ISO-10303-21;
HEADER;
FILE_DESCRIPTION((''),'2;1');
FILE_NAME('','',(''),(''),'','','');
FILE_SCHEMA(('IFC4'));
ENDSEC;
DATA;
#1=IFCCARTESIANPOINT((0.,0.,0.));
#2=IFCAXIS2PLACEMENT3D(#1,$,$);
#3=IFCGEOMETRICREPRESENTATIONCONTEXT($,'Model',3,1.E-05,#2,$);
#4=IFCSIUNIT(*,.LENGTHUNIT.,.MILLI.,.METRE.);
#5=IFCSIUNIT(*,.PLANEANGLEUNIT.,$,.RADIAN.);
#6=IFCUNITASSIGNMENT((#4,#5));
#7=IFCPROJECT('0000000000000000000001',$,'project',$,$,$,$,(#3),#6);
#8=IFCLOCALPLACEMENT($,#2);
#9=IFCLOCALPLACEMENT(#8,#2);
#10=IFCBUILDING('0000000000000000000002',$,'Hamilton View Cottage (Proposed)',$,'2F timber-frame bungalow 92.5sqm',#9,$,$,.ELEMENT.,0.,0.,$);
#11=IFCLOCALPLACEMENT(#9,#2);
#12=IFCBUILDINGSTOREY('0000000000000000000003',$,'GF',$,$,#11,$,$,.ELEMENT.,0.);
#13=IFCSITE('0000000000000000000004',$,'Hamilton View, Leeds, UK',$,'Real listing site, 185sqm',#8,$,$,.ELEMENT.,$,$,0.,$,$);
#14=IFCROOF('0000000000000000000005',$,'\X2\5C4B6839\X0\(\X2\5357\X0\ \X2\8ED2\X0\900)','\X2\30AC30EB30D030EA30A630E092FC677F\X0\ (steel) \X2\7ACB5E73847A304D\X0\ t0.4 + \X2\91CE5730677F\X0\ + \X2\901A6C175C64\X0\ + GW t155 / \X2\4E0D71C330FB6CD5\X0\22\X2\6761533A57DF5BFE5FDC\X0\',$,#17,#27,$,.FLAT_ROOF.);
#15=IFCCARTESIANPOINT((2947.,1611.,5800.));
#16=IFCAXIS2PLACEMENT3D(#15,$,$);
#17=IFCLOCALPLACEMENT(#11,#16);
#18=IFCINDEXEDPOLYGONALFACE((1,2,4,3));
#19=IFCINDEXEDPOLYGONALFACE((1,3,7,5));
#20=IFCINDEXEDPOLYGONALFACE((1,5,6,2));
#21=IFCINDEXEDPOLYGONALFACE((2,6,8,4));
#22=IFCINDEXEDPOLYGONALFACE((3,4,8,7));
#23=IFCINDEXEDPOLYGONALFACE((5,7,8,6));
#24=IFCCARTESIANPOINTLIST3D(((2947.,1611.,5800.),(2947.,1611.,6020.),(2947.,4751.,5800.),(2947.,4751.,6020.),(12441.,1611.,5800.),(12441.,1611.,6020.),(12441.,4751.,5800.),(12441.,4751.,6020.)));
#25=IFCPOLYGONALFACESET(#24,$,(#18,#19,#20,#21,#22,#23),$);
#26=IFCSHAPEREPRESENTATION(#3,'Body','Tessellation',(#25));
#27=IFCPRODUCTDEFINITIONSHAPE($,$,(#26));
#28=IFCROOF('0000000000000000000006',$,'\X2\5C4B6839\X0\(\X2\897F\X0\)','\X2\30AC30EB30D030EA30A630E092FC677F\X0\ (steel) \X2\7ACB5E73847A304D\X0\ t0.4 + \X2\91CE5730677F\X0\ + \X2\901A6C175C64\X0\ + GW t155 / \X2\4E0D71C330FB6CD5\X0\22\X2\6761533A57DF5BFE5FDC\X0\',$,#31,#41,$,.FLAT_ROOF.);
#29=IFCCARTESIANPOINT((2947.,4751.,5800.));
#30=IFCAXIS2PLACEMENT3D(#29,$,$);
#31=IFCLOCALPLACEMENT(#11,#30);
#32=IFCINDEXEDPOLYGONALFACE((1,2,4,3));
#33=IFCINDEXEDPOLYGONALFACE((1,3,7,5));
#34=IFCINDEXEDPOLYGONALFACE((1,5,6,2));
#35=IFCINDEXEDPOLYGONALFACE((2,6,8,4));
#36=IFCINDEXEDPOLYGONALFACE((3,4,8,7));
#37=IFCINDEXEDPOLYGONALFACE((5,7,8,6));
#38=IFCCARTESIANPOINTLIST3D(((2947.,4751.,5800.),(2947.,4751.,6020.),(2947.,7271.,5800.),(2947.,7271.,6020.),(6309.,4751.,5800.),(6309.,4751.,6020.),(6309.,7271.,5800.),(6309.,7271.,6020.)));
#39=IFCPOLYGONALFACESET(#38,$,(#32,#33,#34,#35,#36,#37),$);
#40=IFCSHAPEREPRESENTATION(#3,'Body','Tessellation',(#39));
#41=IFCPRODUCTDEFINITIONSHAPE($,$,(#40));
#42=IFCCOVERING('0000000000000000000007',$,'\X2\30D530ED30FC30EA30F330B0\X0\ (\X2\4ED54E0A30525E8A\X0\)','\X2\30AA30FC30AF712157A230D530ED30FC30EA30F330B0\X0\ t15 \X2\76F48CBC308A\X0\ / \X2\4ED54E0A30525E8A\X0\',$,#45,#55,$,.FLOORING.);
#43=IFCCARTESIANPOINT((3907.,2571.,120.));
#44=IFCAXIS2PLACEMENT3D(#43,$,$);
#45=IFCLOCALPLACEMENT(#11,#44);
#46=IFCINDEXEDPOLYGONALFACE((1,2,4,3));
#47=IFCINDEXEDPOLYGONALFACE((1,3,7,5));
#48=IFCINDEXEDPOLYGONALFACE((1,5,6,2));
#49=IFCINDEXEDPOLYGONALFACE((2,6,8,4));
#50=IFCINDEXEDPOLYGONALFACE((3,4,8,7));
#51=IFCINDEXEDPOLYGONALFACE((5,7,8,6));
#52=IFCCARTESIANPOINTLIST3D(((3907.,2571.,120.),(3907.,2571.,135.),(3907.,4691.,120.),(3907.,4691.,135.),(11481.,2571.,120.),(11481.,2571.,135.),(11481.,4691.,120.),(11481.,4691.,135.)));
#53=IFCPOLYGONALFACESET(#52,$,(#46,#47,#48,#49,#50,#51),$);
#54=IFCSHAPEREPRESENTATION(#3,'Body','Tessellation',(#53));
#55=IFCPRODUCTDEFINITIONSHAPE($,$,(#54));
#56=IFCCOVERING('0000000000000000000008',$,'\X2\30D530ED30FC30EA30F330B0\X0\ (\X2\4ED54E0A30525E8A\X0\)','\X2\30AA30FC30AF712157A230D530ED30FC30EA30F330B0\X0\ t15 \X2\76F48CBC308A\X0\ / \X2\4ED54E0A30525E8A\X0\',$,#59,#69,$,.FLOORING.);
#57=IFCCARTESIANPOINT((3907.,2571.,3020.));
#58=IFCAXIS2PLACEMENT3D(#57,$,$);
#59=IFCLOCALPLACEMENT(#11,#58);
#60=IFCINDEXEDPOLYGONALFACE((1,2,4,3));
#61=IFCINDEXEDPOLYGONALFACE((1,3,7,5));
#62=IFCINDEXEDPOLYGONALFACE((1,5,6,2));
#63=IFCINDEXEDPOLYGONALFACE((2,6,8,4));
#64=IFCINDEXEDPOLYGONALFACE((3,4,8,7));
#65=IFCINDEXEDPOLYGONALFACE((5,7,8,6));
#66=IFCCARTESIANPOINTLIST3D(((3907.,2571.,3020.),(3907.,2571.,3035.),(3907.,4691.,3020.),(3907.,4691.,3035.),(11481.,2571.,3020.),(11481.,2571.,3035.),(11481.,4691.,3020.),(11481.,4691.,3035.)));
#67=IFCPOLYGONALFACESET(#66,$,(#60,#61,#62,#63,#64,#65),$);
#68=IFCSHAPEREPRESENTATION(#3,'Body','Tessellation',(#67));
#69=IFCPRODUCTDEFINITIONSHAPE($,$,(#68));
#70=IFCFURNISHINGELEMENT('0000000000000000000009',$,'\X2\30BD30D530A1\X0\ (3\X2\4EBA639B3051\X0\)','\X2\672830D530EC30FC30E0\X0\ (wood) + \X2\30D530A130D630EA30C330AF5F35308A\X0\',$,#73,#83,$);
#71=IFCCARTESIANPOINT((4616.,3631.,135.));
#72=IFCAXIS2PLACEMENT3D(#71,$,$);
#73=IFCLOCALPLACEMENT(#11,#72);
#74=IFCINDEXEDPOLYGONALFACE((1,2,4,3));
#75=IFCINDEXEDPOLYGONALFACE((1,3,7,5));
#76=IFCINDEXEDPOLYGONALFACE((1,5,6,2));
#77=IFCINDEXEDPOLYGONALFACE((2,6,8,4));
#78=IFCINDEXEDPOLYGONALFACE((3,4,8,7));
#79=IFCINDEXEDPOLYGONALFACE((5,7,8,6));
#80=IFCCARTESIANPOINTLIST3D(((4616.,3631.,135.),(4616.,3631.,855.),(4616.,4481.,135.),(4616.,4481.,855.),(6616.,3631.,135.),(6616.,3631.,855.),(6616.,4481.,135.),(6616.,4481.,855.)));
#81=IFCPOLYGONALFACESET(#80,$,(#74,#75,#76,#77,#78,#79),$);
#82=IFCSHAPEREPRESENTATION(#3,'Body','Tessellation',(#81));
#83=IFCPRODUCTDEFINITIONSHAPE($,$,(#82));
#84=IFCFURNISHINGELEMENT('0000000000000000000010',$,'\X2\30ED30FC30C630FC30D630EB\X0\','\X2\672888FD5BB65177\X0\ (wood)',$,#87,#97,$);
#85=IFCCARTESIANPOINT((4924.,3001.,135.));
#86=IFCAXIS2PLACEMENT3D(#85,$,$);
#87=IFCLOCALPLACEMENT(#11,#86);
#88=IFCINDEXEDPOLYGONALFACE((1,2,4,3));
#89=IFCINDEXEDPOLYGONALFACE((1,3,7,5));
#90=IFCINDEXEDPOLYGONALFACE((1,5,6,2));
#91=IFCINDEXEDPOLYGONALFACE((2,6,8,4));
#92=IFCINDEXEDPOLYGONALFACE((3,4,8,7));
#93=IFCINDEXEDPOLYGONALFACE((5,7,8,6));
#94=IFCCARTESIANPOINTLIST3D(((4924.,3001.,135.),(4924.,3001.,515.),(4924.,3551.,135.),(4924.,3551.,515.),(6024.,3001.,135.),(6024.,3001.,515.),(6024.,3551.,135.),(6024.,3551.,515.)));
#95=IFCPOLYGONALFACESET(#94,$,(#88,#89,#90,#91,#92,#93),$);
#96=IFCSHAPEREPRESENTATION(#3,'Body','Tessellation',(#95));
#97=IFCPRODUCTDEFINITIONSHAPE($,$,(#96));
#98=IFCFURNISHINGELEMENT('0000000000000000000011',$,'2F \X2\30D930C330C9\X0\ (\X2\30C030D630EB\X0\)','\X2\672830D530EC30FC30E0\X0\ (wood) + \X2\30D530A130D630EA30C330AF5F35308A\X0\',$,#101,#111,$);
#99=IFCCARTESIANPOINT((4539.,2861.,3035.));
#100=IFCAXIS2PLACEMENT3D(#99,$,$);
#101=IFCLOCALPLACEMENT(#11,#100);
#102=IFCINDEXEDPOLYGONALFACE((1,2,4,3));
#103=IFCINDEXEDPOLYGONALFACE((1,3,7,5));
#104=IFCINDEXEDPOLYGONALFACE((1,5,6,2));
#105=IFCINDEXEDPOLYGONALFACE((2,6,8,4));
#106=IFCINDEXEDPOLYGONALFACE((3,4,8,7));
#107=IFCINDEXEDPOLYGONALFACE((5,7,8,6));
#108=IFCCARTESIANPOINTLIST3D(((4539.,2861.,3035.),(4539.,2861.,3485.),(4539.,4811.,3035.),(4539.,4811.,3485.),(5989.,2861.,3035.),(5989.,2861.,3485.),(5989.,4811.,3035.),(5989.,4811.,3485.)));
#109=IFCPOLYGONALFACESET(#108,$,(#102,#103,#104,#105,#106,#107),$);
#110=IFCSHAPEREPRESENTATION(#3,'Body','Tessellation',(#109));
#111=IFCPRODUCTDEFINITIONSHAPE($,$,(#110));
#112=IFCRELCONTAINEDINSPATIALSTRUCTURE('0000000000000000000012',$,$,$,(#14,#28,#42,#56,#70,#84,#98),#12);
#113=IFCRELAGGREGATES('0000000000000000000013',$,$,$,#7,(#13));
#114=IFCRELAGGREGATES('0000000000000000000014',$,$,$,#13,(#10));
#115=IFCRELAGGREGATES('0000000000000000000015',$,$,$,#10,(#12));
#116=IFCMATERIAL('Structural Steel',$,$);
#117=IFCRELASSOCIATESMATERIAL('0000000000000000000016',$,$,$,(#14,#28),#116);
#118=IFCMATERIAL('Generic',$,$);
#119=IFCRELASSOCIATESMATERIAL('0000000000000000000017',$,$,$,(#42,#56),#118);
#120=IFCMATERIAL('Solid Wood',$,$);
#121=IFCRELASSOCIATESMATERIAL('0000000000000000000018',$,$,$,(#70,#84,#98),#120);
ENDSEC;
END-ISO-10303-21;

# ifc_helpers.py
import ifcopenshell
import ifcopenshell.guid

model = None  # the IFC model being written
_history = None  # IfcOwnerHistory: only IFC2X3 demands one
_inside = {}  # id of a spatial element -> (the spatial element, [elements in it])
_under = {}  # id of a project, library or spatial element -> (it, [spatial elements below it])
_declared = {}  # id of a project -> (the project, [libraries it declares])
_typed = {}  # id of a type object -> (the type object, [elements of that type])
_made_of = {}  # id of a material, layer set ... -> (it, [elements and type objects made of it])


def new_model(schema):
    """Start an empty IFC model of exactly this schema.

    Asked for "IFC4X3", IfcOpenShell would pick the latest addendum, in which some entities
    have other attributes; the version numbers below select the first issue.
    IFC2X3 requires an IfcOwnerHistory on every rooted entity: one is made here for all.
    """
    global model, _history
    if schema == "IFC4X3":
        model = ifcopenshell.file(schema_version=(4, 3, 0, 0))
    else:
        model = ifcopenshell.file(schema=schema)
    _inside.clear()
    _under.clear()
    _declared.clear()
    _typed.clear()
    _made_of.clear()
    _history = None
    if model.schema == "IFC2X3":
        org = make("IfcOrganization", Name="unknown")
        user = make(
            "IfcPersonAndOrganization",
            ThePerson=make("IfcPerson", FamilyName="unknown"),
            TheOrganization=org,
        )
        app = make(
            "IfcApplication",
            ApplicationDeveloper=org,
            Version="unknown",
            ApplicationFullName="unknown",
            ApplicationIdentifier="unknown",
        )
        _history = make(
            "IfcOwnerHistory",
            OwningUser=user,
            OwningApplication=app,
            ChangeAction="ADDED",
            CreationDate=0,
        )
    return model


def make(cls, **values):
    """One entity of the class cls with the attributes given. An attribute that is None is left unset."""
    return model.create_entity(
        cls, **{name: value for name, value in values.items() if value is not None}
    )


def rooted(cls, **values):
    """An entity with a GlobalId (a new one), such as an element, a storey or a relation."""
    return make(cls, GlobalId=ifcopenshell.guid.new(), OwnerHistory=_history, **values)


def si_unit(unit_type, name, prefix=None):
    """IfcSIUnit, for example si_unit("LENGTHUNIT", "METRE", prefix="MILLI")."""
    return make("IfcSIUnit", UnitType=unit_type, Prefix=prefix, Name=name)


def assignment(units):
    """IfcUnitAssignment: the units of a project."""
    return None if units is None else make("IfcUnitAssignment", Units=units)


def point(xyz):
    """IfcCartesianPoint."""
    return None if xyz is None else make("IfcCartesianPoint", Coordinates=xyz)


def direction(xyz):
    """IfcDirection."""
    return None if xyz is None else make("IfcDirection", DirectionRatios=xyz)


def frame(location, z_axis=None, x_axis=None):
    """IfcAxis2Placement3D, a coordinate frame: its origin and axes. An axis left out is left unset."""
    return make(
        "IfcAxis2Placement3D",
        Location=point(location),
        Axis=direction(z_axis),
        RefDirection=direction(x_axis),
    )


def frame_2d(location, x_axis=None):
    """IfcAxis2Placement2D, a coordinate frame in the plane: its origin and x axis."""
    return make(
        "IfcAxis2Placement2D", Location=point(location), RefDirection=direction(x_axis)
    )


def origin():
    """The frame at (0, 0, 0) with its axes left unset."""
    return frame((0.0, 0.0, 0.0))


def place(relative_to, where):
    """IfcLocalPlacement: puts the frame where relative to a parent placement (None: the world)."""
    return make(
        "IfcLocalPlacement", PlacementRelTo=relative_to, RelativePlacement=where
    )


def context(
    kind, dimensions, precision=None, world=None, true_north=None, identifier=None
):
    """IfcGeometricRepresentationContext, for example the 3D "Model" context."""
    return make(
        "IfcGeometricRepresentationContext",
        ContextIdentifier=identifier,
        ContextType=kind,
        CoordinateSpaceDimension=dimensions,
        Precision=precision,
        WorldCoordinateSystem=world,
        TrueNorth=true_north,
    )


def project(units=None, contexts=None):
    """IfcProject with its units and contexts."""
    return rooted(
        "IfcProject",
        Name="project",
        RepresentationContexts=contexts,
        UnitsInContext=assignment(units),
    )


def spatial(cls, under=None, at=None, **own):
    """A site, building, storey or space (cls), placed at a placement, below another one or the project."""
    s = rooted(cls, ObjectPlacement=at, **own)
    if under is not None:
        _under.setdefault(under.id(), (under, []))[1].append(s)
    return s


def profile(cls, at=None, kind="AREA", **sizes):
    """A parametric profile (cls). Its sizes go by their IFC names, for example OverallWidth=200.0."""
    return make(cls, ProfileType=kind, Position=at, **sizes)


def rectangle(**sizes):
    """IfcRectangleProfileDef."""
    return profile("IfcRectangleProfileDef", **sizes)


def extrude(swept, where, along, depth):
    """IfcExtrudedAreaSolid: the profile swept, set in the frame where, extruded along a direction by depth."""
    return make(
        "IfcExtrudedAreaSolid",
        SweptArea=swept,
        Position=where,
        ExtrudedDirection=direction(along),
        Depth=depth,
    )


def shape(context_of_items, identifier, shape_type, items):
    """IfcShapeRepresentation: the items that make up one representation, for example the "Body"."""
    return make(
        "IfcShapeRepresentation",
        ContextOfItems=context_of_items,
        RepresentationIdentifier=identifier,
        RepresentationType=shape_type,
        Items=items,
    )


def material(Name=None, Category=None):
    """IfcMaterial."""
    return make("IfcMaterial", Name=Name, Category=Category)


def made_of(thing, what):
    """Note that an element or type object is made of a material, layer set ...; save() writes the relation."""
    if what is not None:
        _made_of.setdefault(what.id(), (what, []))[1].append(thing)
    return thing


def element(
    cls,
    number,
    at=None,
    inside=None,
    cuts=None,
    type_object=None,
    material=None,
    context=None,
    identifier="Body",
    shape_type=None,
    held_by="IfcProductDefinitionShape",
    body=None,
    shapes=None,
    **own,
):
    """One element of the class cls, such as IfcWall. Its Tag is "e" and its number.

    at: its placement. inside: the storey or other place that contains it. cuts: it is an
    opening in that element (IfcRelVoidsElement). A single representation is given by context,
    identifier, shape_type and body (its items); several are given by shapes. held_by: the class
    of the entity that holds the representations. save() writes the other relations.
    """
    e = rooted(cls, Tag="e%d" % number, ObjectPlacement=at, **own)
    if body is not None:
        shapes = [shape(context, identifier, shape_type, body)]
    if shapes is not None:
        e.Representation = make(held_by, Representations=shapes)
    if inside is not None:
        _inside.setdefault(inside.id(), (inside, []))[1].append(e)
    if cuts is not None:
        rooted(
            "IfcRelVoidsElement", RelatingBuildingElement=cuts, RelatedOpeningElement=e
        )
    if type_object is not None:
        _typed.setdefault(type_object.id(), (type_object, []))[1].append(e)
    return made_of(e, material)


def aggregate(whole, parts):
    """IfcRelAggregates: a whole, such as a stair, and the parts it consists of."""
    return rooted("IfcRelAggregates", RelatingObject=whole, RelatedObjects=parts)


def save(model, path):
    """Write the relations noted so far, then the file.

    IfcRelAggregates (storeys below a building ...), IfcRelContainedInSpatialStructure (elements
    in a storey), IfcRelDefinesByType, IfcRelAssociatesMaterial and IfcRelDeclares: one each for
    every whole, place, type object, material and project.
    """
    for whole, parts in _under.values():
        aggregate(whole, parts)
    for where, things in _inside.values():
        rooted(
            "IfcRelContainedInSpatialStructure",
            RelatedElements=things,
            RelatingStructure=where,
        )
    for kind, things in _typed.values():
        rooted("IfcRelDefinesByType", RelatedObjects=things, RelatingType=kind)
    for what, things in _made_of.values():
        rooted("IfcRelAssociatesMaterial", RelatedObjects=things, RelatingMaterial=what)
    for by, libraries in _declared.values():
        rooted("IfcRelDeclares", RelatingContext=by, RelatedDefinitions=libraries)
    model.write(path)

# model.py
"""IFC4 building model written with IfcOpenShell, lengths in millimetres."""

from ifc_helpers import new_model, si_unit, frame, frame_2d, origin, place, context, project, spatial, rectangle, extrude, material, element, save


model = new_model("IFC4")

# Units and contexts
model_context = context("Model", 3, precision=1e-05, world=origin())
ifc_project = project(units=[si_unit("LENGTHUNIT", "METRE", prefix="MILLI"), si_unit("PLANEANGLEUNIT", "RADIAN")], contexts=[model_context])

# Site, building, storey
site_placement = place(None, origin())
site = spatial("IfcSite", under=ifc_project, at=site_placement, Name="Hamilton View, Leeds, UK", ObjectType="Real listing site, 185sqm", CompositionType="ELEMENT", RefElevation=0.0)
building_placement = place(site_placement, origin())
building = spatial("IfcBuilding", under=site, at=building_placement, Name="Hamilton View Cottage (Proposed)", ObjectType="2F timber-frame bungalow 92.5sqm", CompositionType="ELEMENT", ElevationOfRefHeight=0.0, ElevationOfTerrain=0.0)
storey_placement = place(building_placement, origin())
storey = spatial("IfcBuildingStorey", under=building, at=storey_placement, Name="GF", CompositionType="ELEMENT", Elevation=0.0)

# Shared definitions
ifc_material_1 = material(Name="Solid Wood")

# Roofs
ifc_material_2 = material(Name="Structural Steel")
roof_1_placement = place(storey_placement, frame((2947.0, 1611.0, 5800.0)))
element("IfcRoof", 1, at=roof_1_placement, inside=storey, material=ifc_material_2, Name="屋根(南 軒900)", Description="ガルバリウム鋼板 (steel) 立平葺き t0.4 + 野地板 + 通気層 + GW t155 / 不燃・法22条区域対応", PredefinedType="FLAT_ROOF", context=model_context, shape_type="SweptSolid", body=[
    extrude(rectangle(XDim=9494.0, YDim=3140.0, at=frame_2d((4747.0, 1570.0))), frame((2947.0, 1611.0, 5800.0)), (0.0, 0.0, 1.0), 220.0),
])
roof_2_placement = place(storey_placement, frame((2947.0, 4751.0, 5800.0)))
element("IfcRoof", 2, at=roof_2_placement, inside=storey, material=ifc_material_2, Name="屋根(西)", Description="ガルバリウム鋼板 (steel) 立平葺き t0.4 + 野地板 + 通気層 + GW t155 / 不燃・法22条区域対応", PredefinedType="FLAT_ROOF", context=model_context, shape_type="SweptSolid", body=[
    extrude(rectangle(XDim=3362.0, YDim=2520.0, at=frame_2d((1681.0, 1260.0))), frame((2947.0, 4751.0, 5800.0)), (0.0, 0.0, 1.0), 220.0),
])

# Coverings
ifc_material_3 = material(Name="Generic")
covering_1_placement = place(storey_placement, frame((3907.0, 2571.0, 120.0)))
element("IfcCovering", 3, at=covering_1_placement, inside=storey, material=ifc_material_3, Name="フローリング (仕上げ床)", Description="オーク無垢フローリング t15 直貼り / 仕上げ床", PredefinedType="FLOORING", context=model_context, shape_type="SweptSolid", body=[
    extrude(rectangle(XDim=7574.0, YDim=2120.0, at=frame_2d((3787.0, 1060.0))), frame((3907.0, 2571.0, 120.0)), (0.0, 0.0, 1.0), 15.0),
])
covering_2_placement = place(storey_placement, frame((3907.0, 2571.0, 3020.0)))
element("IfcCovering", 4, at=covering_2_placement, inside=storey, material=ifc_material_3, Name="フローリング (仕上げ床)", Description="オーク無垢フローリング t15 直貼り / 仕上げ床", PredefinedType="FLOORING", context=model_context, shape_type="SweptSolid", body=[
    extrude(rectangle(XDim=7574.0, YDim=2120.0, at=frame_2d((3787.0, 1060.0))), frame((3907.0, 2571.0, 3020.0)), (0.0, 0.0, 1.0), 15.0),
])

# Furnishing elements
furnishing_1_placement = place(storey_placement, frame((4616.0, 3631.0, 135.0)))
element("IfcFurnishingElement", 5, at=furnishing_1_placement, inside=storey, material=ifc_material_1, Name="ソファ (3人掛け)", Description="木フレーム (wood) + ファブリック張り", context=model_context, shape_type="SweptSolid", body=[
    extrude(rectangle(XDim=2000.0, YDim=850.0, at=frame_2d((1000.0, 425.0))), frame((4616.0, 3631.0, 135.0)), (0.0, 0.0, 1.0), 720.0),
])
furnishing_2_placement = place(storey_placement, frame((4924.0, 3001.0, 135.0)))
element("IfcFurnishingElement", 6, at=furnishing_2_placement, inside=storey, material=ifc_material_1, Name="ローテーブル", Description="木製家具 (wood)", context=model_context, shape_type="SweptSolid", body=[
    extrude(rectangle(XDim=1100.0, YDim=550.0, at=frame_2d((550.0, 275.0))), frame((4924.0, 3001.0, 135.0)), (0.0, 0.0, 1.0), 380.0),
])
furnishing_3_placement = place(storey_placement, frame((4539.0, 2861.0, 3035.0)))
element("IfcFurnishingElement", 7, at=furnishing_3_placement, inside=storey, material=ifc_material_1, Name="2F ベッド (ダブル)", Description="木フレーム (wood) + ファブリック張り", context=model_context, shape_type="SweptSolid", body=[
    extrude(rectangle(XDim=1450.0, YDim=1950.0, at=frame_2d((725.0, 975.0))), frame((4539.0, 2861.0, 3035.0)), (0.0, 0.0, 1.0), 450.0),
])

save(model, "model.ifc")
